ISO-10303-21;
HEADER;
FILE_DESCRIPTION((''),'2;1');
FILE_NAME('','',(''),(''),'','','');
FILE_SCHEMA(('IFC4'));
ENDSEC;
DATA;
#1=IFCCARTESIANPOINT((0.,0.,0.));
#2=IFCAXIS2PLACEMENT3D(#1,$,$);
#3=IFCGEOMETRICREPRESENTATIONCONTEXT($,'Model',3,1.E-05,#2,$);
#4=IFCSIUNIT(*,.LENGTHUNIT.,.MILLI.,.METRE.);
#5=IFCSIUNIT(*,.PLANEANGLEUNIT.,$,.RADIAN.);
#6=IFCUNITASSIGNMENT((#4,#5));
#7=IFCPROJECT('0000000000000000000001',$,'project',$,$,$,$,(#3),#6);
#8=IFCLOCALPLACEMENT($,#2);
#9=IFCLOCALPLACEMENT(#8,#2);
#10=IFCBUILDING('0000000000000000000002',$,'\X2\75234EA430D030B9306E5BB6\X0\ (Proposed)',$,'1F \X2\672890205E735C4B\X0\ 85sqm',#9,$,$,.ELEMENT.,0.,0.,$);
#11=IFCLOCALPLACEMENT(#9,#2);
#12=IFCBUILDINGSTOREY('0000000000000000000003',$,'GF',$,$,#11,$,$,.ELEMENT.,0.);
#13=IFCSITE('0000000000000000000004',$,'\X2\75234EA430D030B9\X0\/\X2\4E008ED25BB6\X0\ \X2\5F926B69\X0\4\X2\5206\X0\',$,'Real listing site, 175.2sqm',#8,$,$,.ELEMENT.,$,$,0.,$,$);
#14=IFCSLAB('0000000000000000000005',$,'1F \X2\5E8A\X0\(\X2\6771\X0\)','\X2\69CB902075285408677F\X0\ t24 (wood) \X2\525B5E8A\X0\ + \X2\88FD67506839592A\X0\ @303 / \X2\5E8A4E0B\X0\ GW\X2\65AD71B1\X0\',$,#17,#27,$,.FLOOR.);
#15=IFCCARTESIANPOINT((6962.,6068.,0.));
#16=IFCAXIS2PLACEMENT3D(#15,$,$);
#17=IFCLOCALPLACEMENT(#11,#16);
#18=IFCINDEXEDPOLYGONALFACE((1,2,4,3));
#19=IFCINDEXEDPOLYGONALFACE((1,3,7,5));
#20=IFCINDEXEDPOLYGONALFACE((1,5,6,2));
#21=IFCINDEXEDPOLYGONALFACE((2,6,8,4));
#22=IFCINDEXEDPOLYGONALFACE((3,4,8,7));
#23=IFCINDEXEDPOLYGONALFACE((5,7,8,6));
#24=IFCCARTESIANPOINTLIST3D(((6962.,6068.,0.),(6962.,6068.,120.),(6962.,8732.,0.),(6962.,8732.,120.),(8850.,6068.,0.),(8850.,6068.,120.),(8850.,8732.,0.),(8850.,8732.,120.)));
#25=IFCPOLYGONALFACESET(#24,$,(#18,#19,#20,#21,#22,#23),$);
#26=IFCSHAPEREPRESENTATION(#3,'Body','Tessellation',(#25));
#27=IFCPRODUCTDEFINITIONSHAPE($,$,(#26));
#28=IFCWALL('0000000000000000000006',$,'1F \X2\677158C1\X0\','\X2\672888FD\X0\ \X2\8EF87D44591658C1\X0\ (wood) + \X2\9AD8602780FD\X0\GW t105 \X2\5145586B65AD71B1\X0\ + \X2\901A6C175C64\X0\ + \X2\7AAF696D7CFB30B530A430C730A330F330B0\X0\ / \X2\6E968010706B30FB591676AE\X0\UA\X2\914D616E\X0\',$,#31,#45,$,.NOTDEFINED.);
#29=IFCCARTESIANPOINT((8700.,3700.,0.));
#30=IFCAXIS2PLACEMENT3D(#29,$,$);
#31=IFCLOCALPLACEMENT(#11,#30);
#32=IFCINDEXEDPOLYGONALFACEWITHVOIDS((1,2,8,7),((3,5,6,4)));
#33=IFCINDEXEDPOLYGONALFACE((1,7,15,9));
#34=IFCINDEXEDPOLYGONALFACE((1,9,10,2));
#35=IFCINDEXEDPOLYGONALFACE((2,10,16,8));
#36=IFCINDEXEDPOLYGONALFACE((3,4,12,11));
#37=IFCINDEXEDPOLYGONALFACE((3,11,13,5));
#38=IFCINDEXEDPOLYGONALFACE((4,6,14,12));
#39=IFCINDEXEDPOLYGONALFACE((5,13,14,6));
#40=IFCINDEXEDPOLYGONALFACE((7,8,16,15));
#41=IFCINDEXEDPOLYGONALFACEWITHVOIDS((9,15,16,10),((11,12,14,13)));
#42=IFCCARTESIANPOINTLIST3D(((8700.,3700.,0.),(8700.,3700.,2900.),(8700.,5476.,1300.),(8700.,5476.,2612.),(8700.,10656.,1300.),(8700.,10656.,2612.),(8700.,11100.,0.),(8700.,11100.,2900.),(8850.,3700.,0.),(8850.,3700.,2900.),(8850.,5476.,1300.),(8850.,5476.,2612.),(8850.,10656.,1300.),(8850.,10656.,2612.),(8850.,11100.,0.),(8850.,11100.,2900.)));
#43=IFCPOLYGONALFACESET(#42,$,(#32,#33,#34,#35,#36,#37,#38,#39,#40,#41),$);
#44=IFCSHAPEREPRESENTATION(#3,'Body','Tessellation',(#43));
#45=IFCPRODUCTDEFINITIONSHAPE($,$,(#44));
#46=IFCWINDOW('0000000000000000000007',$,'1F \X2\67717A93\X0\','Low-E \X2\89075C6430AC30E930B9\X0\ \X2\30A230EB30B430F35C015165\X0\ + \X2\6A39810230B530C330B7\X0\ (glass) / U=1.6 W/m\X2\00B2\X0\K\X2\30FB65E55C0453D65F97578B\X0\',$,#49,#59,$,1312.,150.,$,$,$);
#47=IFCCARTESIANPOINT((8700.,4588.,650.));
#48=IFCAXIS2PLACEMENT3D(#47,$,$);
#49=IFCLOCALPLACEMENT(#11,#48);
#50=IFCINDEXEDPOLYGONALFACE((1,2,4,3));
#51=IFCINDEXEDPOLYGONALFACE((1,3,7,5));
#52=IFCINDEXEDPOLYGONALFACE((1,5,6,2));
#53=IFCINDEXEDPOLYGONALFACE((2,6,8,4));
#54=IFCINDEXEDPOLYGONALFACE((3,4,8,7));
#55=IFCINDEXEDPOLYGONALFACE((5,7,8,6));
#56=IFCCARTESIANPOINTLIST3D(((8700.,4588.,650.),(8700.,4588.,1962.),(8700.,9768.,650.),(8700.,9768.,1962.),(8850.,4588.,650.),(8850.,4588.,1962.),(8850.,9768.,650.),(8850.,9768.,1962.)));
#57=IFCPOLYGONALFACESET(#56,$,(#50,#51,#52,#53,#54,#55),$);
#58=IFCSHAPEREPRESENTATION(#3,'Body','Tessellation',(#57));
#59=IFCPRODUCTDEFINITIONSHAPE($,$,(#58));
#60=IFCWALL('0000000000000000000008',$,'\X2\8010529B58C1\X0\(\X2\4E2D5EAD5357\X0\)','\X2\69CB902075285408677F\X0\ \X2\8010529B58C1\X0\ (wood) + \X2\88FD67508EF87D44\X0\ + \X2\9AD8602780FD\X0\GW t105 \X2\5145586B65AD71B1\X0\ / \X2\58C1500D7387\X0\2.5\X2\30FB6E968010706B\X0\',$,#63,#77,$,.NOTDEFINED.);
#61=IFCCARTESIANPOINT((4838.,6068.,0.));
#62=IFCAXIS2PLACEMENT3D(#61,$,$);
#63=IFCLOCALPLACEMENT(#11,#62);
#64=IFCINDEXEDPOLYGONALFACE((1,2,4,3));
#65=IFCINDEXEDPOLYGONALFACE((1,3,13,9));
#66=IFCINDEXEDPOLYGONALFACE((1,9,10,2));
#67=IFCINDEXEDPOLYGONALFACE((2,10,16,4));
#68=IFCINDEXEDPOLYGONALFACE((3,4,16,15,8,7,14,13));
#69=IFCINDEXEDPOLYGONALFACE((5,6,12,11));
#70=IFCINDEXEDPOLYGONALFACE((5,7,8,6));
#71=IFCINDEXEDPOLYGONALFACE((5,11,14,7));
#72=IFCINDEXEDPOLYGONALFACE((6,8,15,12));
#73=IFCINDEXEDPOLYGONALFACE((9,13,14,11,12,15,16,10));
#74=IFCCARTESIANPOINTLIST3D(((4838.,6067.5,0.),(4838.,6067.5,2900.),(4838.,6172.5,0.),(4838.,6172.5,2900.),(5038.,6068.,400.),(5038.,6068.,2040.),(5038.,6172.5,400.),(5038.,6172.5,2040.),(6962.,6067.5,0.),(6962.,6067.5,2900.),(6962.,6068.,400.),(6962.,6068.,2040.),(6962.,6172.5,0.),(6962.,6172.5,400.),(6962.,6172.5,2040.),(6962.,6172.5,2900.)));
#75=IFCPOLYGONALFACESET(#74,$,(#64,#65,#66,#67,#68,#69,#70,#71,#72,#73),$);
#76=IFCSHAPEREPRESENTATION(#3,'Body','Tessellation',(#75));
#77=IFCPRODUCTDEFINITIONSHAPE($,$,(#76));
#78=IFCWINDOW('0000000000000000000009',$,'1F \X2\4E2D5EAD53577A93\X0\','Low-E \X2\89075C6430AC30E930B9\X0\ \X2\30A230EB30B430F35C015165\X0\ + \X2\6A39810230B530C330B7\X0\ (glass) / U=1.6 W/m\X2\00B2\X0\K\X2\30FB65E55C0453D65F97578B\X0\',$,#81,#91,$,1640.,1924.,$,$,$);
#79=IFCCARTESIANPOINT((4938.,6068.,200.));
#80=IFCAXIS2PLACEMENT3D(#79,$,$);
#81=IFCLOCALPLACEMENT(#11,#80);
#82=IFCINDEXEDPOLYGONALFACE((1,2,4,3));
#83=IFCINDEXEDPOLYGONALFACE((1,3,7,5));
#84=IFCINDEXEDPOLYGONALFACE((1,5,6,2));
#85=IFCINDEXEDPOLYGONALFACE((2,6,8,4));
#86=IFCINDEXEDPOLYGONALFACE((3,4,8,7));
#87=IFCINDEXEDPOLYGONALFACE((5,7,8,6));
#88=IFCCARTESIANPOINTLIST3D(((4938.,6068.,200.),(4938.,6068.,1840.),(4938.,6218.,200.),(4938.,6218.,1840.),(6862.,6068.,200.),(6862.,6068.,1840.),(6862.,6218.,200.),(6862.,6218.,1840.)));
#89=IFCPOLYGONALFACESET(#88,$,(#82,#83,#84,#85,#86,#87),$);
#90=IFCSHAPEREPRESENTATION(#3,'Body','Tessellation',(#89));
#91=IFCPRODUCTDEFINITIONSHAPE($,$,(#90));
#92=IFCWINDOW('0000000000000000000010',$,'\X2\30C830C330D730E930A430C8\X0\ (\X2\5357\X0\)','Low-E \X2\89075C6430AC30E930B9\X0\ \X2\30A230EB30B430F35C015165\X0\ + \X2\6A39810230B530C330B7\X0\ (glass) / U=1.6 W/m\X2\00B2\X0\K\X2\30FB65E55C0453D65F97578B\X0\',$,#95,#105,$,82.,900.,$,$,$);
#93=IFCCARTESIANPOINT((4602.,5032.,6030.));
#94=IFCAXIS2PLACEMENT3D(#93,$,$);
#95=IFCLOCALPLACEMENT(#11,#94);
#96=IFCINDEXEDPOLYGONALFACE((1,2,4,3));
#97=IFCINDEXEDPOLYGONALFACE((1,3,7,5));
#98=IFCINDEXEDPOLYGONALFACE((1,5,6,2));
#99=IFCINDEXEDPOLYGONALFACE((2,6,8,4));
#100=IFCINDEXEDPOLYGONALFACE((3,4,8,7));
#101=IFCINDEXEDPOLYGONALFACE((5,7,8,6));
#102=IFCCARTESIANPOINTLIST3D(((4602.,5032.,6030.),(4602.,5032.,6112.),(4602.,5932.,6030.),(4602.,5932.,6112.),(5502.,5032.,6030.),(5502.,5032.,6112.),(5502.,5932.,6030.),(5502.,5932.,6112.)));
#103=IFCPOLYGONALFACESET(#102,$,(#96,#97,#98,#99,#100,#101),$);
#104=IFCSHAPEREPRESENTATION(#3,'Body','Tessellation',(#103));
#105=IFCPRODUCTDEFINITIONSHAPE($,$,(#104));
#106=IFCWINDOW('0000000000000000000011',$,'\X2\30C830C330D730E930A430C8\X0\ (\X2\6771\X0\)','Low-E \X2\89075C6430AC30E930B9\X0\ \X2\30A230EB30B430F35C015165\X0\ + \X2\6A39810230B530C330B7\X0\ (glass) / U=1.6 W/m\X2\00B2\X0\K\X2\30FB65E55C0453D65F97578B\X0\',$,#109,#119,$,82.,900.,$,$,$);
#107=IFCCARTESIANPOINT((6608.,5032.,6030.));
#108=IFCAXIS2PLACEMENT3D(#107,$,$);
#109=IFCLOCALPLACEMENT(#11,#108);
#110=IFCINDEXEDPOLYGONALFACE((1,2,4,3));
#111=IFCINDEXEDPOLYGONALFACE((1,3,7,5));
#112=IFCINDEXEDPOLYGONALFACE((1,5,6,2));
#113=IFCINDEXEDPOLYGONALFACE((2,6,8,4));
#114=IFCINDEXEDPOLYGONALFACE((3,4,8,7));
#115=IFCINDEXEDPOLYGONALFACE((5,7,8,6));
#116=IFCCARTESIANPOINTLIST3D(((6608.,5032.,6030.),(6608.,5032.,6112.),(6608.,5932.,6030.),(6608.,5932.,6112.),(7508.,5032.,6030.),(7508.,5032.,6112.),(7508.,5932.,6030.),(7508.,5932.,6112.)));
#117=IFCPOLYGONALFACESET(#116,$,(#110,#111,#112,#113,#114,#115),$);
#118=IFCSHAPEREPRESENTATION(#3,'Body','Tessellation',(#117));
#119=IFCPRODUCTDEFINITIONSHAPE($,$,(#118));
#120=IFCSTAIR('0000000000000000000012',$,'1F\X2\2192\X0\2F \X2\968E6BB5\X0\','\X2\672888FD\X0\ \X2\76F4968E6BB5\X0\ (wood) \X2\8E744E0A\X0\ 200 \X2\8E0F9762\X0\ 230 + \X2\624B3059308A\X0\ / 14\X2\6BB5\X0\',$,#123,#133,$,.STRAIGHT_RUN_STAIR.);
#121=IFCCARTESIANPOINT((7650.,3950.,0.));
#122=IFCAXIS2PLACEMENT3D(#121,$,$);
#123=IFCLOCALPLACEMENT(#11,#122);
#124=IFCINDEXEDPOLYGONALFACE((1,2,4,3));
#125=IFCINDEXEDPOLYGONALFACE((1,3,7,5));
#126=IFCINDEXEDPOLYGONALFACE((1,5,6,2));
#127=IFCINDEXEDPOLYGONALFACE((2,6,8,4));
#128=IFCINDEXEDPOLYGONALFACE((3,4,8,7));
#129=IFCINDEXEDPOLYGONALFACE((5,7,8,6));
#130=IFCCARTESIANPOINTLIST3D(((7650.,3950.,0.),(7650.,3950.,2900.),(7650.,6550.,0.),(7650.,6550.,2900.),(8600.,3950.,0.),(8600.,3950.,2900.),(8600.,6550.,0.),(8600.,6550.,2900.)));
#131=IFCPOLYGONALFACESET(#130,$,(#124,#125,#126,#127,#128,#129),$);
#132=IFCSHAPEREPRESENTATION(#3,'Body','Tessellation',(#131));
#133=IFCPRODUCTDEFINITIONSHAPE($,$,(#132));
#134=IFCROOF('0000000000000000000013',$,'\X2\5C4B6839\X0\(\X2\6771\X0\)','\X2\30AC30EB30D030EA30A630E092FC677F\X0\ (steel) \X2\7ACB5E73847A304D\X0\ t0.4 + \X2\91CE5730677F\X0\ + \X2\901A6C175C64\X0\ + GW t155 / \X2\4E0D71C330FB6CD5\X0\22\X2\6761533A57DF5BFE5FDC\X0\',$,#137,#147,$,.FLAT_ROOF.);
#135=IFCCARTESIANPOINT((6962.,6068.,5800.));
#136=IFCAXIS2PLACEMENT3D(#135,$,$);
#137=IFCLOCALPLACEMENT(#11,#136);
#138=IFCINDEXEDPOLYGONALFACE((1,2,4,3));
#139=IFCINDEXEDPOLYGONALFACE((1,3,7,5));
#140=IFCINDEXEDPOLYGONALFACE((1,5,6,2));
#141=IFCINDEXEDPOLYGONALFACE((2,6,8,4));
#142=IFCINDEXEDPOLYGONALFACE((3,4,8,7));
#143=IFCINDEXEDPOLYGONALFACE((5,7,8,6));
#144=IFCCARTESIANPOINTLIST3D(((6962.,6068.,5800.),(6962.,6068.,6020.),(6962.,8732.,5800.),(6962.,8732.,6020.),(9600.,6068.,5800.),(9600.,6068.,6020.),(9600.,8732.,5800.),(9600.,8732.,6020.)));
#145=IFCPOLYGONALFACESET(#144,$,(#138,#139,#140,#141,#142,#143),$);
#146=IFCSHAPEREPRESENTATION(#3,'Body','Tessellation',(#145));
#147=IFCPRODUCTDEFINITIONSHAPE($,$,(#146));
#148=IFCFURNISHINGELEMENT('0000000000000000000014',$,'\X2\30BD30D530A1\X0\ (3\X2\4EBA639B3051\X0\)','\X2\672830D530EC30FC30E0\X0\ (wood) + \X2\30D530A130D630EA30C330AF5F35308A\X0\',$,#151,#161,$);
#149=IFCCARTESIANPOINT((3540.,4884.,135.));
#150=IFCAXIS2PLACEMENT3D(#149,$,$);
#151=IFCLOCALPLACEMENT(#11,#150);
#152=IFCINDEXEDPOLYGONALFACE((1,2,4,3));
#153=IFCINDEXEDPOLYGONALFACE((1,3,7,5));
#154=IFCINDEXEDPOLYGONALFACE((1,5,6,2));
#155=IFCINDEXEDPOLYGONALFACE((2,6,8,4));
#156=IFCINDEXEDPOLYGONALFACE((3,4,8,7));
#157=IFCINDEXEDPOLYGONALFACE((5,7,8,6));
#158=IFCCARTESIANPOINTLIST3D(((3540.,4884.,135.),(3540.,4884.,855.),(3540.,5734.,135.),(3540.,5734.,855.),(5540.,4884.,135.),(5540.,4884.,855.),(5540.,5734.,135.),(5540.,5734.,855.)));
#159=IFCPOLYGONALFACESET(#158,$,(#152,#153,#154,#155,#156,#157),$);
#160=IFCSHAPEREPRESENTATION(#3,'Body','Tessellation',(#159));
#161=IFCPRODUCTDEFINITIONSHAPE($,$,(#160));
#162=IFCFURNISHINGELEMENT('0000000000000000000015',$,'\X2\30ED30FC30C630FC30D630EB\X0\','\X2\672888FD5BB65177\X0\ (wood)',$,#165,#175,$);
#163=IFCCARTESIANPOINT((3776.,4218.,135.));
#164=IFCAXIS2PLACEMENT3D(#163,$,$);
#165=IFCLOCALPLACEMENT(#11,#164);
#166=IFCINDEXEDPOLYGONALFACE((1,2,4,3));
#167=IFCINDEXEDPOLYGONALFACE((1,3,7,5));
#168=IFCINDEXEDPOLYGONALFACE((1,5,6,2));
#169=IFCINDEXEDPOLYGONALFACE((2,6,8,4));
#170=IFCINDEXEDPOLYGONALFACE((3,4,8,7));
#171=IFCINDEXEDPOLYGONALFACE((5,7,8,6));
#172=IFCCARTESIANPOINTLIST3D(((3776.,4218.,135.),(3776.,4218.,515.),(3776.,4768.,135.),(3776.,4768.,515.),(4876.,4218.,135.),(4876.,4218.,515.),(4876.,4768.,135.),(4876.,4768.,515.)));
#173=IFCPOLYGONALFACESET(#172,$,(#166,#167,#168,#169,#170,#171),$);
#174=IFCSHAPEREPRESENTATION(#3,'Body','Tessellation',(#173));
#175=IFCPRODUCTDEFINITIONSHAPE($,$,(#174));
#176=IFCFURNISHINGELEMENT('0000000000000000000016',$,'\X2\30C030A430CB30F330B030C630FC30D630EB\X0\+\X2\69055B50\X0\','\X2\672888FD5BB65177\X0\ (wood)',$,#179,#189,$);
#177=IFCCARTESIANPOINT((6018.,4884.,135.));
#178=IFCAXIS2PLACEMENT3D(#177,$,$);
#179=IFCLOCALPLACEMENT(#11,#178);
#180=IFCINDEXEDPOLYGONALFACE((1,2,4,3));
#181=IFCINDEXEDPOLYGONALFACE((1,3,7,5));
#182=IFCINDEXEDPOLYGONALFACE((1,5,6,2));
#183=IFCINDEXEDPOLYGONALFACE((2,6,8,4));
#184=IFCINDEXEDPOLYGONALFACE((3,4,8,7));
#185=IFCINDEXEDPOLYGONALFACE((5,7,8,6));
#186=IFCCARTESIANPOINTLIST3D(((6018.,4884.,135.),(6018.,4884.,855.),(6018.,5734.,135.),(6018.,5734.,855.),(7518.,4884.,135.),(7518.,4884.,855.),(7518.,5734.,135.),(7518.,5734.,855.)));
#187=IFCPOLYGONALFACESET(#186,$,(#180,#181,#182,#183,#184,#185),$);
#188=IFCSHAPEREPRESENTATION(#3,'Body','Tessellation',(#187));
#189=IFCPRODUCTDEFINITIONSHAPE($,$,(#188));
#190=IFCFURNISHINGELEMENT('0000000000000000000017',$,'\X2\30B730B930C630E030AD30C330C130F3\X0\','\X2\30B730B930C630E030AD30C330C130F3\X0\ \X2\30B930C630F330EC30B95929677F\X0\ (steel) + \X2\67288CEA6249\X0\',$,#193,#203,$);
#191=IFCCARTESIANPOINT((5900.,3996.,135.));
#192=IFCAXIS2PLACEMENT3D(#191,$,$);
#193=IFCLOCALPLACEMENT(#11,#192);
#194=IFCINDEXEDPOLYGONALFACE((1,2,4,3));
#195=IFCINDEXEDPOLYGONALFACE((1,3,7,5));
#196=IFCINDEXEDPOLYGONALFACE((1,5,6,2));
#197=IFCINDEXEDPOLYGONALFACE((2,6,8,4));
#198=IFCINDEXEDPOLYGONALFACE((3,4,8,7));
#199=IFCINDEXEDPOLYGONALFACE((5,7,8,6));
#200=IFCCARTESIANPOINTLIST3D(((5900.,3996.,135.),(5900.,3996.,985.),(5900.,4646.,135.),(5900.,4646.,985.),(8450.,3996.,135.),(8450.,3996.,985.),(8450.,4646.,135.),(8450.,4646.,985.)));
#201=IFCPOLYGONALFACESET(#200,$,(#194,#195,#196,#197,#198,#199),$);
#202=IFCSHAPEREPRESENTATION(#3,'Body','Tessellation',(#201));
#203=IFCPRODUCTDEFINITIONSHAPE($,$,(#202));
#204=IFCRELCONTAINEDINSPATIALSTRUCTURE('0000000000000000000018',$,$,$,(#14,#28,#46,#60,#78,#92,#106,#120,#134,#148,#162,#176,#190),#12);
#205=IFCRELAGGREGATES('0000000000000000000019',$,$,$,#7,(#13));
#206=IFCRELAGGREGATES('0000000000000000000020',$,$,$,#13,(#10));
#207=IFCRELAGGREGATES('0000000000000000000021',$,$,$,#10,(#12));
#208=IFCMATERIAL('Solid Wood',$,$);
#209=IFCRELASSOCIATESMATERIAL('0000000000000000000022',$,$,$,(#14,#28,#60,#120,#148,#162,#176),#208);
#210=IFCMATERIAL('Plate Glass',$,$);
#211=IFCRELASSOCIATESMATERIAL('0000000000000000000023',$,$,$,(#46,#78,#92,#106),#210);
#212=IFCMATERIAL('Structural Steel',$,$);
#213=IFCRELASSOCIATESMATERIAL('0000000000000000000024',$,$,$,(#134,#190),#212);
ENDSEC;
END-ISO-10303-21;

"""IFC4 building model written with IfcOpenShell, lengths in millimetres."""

from ifc_helpers import new_model, si_unit, frame, frame_2d, origin, place, context, project, spatial, rectangle, extrude, material, element, fill, save


model = new_model("IFC4")

# Units and contexts
model_context = context("Model", 3, precision=1e-05, world=origin())
ifc_project = project(units=[si_unit("LENGTHUNIT", "METRE", prefix="MILLI"), si_unit("PLANEANGLEUNIT", "RADIAN")], contexts=[model_context])

# Site, building, storey
site_placement = place(None, origin())
site = spatial("IfcSite", under=ifc_project, at=site_placement, Name="産交バス/一軒家 徒歩4分", ObjectType="Real listing site, 175.2sqm", CompositionType="ELEMENT", RefElevation=0.0)
building_placement = place(site_placement, origin())
building = spatial("IfcBuilding", under=site, at=building_placement, Name="産交バスの家 (Proposed)", ObjectType="1F 木造平屋 85sqm", CompositionType="ELEMENT", ElevationOfRefHeight=0.0, ElevationOfTerrain=0.0)
storey_placement = place(building_placement, origin())
storey = spatial("IfcBuildingStorey", under=building, at=storey_placement, Name="GF", CompositionType="ELEMENT", Elevation=0.0)

# Slab
ifc_material_1 = material(Name="Solid Wood")
slab_placement = place(storey_placement, frame((6962.0, 6068.0, 0.0)))
element("IfcSlab", 1, at=slab_placement, inside=storey, material=ifc_material_1, Name="1F 床(東)", Description="構造用合板 t24 (wood) 剛床 + 製材根太 @303 / 床下 GW断熱", PredefinedType="FLOOR", context=model_context, shape_type="SweptSolid", body=[
    extrude(rectangle(XDim=1888.0, YDim=2664.0, at=frame_2d((944.0, 1332.0))), frame((6962.0, 6068.0, 0.0)), (0.0, 0.0, 1.0), 120.0),
])

# Walls, openings, windows
wall_1_placement = place(storey_placement, frame((8700.0, 3700.0, 0.0)))
wall_1 = element("IfcWall", 2, at=wall_1_placement, inside=storey, material=ifc_material_1, Name="1F 東壁", Description="木製 軸組外壁 (wood) + 高性能GW t105 充填断熱 + 通気層 + 窯業系サイディング / 準耐火・外皮UA配慮", PredefinedType="NOTDEFINED", context=model_context, shape_type="SweptSolid", body=[
    extrude(rectangle(XDim=150.0, YDim=7400.0, at=frame_2d((75.0, 3700.0))), frame((8700.0, 3700.0, 0.0)), (0.0, 0.0, 1.0), 2900.0),
])
opening_1_placement = place(storey_placement, frame((8700.0, 4588.0, 650.0)))
opening_1 = element("IfcOpeningElement", 3, at=opening_1_placement, cuts=wall_1, PredefinedType="NOTDEFINED", context=model_context, shape_type="SweptSolid", body=[
    extrude(rectangle(XDim=150.0, YDim=5180.0, at=frame_2d((75.0, 2590.0))), frame((8700.0, 4588.0, 650.0)), (0.0, 0.0, 1.0), 1312.0),
])
ifc_material_2 = material(Name="Plate Glass")
window_1_placement = place(storey_placement, frame((8700.0, 4588.0, 650.0)))
window_1 = element("IfcWindow", 4, at=window_1_placement, inside=storey, material=ifc_material_2, Name="1F 東窓", Description="Low-E 複層ガラス アルゴン封入 + 樹脂サッシ (glass) / U=1.6 W/m²K・日射取得型", OverallHeight=1312.0, OverallWidth=150.0, context=model_context, shape_type="SweptSolid", body=[
    extrude(rectangle(XDim=150.0, YDim=5180.0, at=frame_2d((75.0, 2590.0))), frame((8700.0, 4588.0, 650.0)), (0.0, 0.0, 1.0), 1312.0),
])
fill(opening_1, window_1)
wall_2_placement = place(storey_placement, frame((4838.0, 6068.0, 0.0)))
wall_2 = element("IfcWall", 5, at=wall_2_placement, inside=storey, material=ifc_material_1, Name="耐力壁(中庭南)", Description="構造用合板 耐力壁 (wood) + 製材軸組 + 高性能GW t105 充填断熱 / 壁倍率2.5・準耐火", PredefinedType="NOTDEFINED", context=model_context, shape_type="SweptSolid", body=[
    extrude(rectangle(XDim=2124.0, YDim=105.0, at=frame_2d((1062.0, 52.0))), frame((4838.0, 6068.0, 0.0)), (0.0, 0.0, 1.0), 2900.0),
])
opening_2_placement = place(storey_placement, frame((4938.0, 6068.0, 200.0)))
opening_2 = element("IfcOpeningElement", 6, at=opening_2_placement, cuts=wall_2, PredefinedType="NOTDEFINED", context=model_context, shape_type="SweptSolid", body=[
    extrude(rectangle(XDim=1924.0, YDim=150.0, at=frame_2d((962.0, 75.0))), frame((4938.0, 6068.0, 200.0)), (0.0, 0.0, 1.0), 1640.0),
])
window_2_placement = place(storey_placement, frame((4938.0, 6068.0, 200.0)))
window_2 = element("IfcWindow", 7, at=window_2_placement, inside=storey, material=ifc_material_2, Name="1F 中庭南窓", Description="Low-E 複層ガラス アルゴン封入 + 樹脂サッシ (glass) / U=1.6 W/m²K・日射取得型", OverallHeight=1640.0, OverallWidth=1924.0, context=model_context, shape_type="SweptSolid", body=[
    extrude(rectangle(XDim=1924.0, YDim=150.0, at=frame_2d((962.0, 75.0))), frame((4938.0, 6068.0, 200.0)), (0.0, 0.0, 1.0), 1640.0),
])
fill(opening_2, window_2)

# Windows
window_3_placement = place(storey_placement, frame((4602.0, 5032.0, 6030.0)))
element("IfcWindow", 8, at=window_3_placement, inside=storey, material=ifc_material_2, Name="トップライト (南)", Description="Low-E 複層ガラス アルゴン封入 + 樹脂サッシ (glass) / U=1.6 W/m²K・日射取得型", OverallHeight=82.0, OverallWidth=900.0, context=model_context, shape_type="SweptSolid", body=[
    extrude(rectangle(XDim=900.0, YDim=900.0, at=frame_2d((450.0, 450.0))), frame((4602.0, 5032.0, 6030.0)), (0.0, 0.0, 1.0), 82.0),
])
window_4_placement = place(storey_placement, frame((6608.0, 5032.0, 6030.0)))
element("IfcWindow", 9, at=window_4_placement, inside=storey, material=ifc_material_2, Name="トップライト (東)", Description="Low-E 複層ガラス アルゴン封入 + 樹脂サッシ (glass) / U=1.6 W/m²K・日射取得型", OverallHeight=82.0, OverallWidth=900.0, context=model_context, shape_type="SweptSolid", body=[
    extrude(rectangle(XDim=900.0, YDim=900.0, at=frame_2d((450.0, 450.0))), frame((6608.0, 5032.0, 6030.0)), (0.0, 0.0, 1.0), 82.0),
])

# Stair
stair_placement = place(storey_placement, frame((7650.0, 3950.0, 0.0)))
element("IfcStair", 10, at=stair_placement, inside=storey, material=ifc_material_1, Name="1F→2F 階段", Description="木製 直階段 (wood) 蹴上 200 踏面 230 + 手すり / 14段", PredefinedType="STRAIGHT_RUN_STAIR", context=model_context, shape_type="SweptSolid", body=[
    extrude(rectangle(XDim=950.0, YDim=2600.0, at=frame_2d((475.0, 1300.0))), frame((7650.0, 3950.0, 0.0)), (0.0, 0.0, 1.0), 2900.0),
])

# Roof
ifc_material_3 = material(Name="Structural Steel")
roof_placement = place(storey_placement, frame((6962.0, 6068.0, 5800.0)))
element("IfcRoof", 11, at=roof_placement, inside=storey, material=ifc_material_3, Name="屋根(東)", Description="ガルバリウム鋼板 (steel) 立平葺き t0.4 + 野地板 + 通気層 + GW t155 / 不燃・法22条区域対応", PredefinedType="FLAT_ROOF", context=model_context, shape_type="SweptSolid", body=[
    extrude(rectangle(XDim=2638.0, YDim=2664.0, at=frame_2d((1319.0, 1332.0))), frame((6962.0, 6068.0, 5800.0)), (0.0, 0.0, 1.0), 220.0),
])

# Furnishing elements
furnishing_1_placement = place(storey_placement, frame((3540.0, 4884.0, 135.0)))
element("IfcFurnishingElement", 12, at=furnishing_1_placement, inside=storey, material=ifc_material_1, Name="ソファ (3人掛け)", Description="木フレーム (wood) + ファブリック張り", context=model_context, shape_type="SweptSolid", body=[
    extrude(rectangle(XDim=2000.0, YDim=850.0, at=frame_2d((1000.0, 425.0))), frame((3540.0, 4884.0, 135.0)), (0.0, 0.0, 1.0), 720.0),
])
furnishing_2_placement = place(storey_placement, frame((3776.0, 4218.0, 135.0)))
element("IfcFurnishingElement", 13, at=furnishing_2_placement, inside=storey, material=ifc_material_1, Name="ローテーブル", Description="木製家具 (wood)", context=model_context, shape_type="SweptSolid", body=[
    extrude(rectangle(XDim=1100.0, YDim=550.0, at=frame_2d((550.0, 275.0))), frame((3776.0, 4218.0, 135.0)), (0.0, 0.0, 1.0), 380.0),
])
furnishing_3_placement = place(storey_placement, frame((6018.0, 4884.0, 135.0)))
element("IfcFurnishingElement", 14, at=furnishing_3_placement, inside=storey, material=ifc_material_1, Name="ダイニングテーブル+椅子", Description="木製家具 (wood)", context=model_context, shape_type="SweptSolid", body=[
    extrude(rectangle(XDim=1500.0, YDim=850.0, at=frame_2d((750.0, 425.0))), frame((6018.0, 4884.0, 135.0)), (0.0, 0.0, 1.0), 720.0),
])
furnishing_4_placement = place(storey_placement, frame((5900.0, 3996.0, 135.0)))
element("IfcFurnishingElement", 15, at=furnishing_4_placement, inside=storey, material=ifc_material_3, Name="システムキッチン", Description="システムキッチン ステンレス天板 (steel) + 木質扉", context=model_context, shape_type="SweptSolid", body=[
    extrude(rectangle(XDim=2550.0, YDim=650.0, at=frame_2d((1275.0, 325.0))), frame((5900.0, 3996.0, 135.0)), (0.0, 0.0, 1.0), 850.0),
])

save(model, "model.ifc")
